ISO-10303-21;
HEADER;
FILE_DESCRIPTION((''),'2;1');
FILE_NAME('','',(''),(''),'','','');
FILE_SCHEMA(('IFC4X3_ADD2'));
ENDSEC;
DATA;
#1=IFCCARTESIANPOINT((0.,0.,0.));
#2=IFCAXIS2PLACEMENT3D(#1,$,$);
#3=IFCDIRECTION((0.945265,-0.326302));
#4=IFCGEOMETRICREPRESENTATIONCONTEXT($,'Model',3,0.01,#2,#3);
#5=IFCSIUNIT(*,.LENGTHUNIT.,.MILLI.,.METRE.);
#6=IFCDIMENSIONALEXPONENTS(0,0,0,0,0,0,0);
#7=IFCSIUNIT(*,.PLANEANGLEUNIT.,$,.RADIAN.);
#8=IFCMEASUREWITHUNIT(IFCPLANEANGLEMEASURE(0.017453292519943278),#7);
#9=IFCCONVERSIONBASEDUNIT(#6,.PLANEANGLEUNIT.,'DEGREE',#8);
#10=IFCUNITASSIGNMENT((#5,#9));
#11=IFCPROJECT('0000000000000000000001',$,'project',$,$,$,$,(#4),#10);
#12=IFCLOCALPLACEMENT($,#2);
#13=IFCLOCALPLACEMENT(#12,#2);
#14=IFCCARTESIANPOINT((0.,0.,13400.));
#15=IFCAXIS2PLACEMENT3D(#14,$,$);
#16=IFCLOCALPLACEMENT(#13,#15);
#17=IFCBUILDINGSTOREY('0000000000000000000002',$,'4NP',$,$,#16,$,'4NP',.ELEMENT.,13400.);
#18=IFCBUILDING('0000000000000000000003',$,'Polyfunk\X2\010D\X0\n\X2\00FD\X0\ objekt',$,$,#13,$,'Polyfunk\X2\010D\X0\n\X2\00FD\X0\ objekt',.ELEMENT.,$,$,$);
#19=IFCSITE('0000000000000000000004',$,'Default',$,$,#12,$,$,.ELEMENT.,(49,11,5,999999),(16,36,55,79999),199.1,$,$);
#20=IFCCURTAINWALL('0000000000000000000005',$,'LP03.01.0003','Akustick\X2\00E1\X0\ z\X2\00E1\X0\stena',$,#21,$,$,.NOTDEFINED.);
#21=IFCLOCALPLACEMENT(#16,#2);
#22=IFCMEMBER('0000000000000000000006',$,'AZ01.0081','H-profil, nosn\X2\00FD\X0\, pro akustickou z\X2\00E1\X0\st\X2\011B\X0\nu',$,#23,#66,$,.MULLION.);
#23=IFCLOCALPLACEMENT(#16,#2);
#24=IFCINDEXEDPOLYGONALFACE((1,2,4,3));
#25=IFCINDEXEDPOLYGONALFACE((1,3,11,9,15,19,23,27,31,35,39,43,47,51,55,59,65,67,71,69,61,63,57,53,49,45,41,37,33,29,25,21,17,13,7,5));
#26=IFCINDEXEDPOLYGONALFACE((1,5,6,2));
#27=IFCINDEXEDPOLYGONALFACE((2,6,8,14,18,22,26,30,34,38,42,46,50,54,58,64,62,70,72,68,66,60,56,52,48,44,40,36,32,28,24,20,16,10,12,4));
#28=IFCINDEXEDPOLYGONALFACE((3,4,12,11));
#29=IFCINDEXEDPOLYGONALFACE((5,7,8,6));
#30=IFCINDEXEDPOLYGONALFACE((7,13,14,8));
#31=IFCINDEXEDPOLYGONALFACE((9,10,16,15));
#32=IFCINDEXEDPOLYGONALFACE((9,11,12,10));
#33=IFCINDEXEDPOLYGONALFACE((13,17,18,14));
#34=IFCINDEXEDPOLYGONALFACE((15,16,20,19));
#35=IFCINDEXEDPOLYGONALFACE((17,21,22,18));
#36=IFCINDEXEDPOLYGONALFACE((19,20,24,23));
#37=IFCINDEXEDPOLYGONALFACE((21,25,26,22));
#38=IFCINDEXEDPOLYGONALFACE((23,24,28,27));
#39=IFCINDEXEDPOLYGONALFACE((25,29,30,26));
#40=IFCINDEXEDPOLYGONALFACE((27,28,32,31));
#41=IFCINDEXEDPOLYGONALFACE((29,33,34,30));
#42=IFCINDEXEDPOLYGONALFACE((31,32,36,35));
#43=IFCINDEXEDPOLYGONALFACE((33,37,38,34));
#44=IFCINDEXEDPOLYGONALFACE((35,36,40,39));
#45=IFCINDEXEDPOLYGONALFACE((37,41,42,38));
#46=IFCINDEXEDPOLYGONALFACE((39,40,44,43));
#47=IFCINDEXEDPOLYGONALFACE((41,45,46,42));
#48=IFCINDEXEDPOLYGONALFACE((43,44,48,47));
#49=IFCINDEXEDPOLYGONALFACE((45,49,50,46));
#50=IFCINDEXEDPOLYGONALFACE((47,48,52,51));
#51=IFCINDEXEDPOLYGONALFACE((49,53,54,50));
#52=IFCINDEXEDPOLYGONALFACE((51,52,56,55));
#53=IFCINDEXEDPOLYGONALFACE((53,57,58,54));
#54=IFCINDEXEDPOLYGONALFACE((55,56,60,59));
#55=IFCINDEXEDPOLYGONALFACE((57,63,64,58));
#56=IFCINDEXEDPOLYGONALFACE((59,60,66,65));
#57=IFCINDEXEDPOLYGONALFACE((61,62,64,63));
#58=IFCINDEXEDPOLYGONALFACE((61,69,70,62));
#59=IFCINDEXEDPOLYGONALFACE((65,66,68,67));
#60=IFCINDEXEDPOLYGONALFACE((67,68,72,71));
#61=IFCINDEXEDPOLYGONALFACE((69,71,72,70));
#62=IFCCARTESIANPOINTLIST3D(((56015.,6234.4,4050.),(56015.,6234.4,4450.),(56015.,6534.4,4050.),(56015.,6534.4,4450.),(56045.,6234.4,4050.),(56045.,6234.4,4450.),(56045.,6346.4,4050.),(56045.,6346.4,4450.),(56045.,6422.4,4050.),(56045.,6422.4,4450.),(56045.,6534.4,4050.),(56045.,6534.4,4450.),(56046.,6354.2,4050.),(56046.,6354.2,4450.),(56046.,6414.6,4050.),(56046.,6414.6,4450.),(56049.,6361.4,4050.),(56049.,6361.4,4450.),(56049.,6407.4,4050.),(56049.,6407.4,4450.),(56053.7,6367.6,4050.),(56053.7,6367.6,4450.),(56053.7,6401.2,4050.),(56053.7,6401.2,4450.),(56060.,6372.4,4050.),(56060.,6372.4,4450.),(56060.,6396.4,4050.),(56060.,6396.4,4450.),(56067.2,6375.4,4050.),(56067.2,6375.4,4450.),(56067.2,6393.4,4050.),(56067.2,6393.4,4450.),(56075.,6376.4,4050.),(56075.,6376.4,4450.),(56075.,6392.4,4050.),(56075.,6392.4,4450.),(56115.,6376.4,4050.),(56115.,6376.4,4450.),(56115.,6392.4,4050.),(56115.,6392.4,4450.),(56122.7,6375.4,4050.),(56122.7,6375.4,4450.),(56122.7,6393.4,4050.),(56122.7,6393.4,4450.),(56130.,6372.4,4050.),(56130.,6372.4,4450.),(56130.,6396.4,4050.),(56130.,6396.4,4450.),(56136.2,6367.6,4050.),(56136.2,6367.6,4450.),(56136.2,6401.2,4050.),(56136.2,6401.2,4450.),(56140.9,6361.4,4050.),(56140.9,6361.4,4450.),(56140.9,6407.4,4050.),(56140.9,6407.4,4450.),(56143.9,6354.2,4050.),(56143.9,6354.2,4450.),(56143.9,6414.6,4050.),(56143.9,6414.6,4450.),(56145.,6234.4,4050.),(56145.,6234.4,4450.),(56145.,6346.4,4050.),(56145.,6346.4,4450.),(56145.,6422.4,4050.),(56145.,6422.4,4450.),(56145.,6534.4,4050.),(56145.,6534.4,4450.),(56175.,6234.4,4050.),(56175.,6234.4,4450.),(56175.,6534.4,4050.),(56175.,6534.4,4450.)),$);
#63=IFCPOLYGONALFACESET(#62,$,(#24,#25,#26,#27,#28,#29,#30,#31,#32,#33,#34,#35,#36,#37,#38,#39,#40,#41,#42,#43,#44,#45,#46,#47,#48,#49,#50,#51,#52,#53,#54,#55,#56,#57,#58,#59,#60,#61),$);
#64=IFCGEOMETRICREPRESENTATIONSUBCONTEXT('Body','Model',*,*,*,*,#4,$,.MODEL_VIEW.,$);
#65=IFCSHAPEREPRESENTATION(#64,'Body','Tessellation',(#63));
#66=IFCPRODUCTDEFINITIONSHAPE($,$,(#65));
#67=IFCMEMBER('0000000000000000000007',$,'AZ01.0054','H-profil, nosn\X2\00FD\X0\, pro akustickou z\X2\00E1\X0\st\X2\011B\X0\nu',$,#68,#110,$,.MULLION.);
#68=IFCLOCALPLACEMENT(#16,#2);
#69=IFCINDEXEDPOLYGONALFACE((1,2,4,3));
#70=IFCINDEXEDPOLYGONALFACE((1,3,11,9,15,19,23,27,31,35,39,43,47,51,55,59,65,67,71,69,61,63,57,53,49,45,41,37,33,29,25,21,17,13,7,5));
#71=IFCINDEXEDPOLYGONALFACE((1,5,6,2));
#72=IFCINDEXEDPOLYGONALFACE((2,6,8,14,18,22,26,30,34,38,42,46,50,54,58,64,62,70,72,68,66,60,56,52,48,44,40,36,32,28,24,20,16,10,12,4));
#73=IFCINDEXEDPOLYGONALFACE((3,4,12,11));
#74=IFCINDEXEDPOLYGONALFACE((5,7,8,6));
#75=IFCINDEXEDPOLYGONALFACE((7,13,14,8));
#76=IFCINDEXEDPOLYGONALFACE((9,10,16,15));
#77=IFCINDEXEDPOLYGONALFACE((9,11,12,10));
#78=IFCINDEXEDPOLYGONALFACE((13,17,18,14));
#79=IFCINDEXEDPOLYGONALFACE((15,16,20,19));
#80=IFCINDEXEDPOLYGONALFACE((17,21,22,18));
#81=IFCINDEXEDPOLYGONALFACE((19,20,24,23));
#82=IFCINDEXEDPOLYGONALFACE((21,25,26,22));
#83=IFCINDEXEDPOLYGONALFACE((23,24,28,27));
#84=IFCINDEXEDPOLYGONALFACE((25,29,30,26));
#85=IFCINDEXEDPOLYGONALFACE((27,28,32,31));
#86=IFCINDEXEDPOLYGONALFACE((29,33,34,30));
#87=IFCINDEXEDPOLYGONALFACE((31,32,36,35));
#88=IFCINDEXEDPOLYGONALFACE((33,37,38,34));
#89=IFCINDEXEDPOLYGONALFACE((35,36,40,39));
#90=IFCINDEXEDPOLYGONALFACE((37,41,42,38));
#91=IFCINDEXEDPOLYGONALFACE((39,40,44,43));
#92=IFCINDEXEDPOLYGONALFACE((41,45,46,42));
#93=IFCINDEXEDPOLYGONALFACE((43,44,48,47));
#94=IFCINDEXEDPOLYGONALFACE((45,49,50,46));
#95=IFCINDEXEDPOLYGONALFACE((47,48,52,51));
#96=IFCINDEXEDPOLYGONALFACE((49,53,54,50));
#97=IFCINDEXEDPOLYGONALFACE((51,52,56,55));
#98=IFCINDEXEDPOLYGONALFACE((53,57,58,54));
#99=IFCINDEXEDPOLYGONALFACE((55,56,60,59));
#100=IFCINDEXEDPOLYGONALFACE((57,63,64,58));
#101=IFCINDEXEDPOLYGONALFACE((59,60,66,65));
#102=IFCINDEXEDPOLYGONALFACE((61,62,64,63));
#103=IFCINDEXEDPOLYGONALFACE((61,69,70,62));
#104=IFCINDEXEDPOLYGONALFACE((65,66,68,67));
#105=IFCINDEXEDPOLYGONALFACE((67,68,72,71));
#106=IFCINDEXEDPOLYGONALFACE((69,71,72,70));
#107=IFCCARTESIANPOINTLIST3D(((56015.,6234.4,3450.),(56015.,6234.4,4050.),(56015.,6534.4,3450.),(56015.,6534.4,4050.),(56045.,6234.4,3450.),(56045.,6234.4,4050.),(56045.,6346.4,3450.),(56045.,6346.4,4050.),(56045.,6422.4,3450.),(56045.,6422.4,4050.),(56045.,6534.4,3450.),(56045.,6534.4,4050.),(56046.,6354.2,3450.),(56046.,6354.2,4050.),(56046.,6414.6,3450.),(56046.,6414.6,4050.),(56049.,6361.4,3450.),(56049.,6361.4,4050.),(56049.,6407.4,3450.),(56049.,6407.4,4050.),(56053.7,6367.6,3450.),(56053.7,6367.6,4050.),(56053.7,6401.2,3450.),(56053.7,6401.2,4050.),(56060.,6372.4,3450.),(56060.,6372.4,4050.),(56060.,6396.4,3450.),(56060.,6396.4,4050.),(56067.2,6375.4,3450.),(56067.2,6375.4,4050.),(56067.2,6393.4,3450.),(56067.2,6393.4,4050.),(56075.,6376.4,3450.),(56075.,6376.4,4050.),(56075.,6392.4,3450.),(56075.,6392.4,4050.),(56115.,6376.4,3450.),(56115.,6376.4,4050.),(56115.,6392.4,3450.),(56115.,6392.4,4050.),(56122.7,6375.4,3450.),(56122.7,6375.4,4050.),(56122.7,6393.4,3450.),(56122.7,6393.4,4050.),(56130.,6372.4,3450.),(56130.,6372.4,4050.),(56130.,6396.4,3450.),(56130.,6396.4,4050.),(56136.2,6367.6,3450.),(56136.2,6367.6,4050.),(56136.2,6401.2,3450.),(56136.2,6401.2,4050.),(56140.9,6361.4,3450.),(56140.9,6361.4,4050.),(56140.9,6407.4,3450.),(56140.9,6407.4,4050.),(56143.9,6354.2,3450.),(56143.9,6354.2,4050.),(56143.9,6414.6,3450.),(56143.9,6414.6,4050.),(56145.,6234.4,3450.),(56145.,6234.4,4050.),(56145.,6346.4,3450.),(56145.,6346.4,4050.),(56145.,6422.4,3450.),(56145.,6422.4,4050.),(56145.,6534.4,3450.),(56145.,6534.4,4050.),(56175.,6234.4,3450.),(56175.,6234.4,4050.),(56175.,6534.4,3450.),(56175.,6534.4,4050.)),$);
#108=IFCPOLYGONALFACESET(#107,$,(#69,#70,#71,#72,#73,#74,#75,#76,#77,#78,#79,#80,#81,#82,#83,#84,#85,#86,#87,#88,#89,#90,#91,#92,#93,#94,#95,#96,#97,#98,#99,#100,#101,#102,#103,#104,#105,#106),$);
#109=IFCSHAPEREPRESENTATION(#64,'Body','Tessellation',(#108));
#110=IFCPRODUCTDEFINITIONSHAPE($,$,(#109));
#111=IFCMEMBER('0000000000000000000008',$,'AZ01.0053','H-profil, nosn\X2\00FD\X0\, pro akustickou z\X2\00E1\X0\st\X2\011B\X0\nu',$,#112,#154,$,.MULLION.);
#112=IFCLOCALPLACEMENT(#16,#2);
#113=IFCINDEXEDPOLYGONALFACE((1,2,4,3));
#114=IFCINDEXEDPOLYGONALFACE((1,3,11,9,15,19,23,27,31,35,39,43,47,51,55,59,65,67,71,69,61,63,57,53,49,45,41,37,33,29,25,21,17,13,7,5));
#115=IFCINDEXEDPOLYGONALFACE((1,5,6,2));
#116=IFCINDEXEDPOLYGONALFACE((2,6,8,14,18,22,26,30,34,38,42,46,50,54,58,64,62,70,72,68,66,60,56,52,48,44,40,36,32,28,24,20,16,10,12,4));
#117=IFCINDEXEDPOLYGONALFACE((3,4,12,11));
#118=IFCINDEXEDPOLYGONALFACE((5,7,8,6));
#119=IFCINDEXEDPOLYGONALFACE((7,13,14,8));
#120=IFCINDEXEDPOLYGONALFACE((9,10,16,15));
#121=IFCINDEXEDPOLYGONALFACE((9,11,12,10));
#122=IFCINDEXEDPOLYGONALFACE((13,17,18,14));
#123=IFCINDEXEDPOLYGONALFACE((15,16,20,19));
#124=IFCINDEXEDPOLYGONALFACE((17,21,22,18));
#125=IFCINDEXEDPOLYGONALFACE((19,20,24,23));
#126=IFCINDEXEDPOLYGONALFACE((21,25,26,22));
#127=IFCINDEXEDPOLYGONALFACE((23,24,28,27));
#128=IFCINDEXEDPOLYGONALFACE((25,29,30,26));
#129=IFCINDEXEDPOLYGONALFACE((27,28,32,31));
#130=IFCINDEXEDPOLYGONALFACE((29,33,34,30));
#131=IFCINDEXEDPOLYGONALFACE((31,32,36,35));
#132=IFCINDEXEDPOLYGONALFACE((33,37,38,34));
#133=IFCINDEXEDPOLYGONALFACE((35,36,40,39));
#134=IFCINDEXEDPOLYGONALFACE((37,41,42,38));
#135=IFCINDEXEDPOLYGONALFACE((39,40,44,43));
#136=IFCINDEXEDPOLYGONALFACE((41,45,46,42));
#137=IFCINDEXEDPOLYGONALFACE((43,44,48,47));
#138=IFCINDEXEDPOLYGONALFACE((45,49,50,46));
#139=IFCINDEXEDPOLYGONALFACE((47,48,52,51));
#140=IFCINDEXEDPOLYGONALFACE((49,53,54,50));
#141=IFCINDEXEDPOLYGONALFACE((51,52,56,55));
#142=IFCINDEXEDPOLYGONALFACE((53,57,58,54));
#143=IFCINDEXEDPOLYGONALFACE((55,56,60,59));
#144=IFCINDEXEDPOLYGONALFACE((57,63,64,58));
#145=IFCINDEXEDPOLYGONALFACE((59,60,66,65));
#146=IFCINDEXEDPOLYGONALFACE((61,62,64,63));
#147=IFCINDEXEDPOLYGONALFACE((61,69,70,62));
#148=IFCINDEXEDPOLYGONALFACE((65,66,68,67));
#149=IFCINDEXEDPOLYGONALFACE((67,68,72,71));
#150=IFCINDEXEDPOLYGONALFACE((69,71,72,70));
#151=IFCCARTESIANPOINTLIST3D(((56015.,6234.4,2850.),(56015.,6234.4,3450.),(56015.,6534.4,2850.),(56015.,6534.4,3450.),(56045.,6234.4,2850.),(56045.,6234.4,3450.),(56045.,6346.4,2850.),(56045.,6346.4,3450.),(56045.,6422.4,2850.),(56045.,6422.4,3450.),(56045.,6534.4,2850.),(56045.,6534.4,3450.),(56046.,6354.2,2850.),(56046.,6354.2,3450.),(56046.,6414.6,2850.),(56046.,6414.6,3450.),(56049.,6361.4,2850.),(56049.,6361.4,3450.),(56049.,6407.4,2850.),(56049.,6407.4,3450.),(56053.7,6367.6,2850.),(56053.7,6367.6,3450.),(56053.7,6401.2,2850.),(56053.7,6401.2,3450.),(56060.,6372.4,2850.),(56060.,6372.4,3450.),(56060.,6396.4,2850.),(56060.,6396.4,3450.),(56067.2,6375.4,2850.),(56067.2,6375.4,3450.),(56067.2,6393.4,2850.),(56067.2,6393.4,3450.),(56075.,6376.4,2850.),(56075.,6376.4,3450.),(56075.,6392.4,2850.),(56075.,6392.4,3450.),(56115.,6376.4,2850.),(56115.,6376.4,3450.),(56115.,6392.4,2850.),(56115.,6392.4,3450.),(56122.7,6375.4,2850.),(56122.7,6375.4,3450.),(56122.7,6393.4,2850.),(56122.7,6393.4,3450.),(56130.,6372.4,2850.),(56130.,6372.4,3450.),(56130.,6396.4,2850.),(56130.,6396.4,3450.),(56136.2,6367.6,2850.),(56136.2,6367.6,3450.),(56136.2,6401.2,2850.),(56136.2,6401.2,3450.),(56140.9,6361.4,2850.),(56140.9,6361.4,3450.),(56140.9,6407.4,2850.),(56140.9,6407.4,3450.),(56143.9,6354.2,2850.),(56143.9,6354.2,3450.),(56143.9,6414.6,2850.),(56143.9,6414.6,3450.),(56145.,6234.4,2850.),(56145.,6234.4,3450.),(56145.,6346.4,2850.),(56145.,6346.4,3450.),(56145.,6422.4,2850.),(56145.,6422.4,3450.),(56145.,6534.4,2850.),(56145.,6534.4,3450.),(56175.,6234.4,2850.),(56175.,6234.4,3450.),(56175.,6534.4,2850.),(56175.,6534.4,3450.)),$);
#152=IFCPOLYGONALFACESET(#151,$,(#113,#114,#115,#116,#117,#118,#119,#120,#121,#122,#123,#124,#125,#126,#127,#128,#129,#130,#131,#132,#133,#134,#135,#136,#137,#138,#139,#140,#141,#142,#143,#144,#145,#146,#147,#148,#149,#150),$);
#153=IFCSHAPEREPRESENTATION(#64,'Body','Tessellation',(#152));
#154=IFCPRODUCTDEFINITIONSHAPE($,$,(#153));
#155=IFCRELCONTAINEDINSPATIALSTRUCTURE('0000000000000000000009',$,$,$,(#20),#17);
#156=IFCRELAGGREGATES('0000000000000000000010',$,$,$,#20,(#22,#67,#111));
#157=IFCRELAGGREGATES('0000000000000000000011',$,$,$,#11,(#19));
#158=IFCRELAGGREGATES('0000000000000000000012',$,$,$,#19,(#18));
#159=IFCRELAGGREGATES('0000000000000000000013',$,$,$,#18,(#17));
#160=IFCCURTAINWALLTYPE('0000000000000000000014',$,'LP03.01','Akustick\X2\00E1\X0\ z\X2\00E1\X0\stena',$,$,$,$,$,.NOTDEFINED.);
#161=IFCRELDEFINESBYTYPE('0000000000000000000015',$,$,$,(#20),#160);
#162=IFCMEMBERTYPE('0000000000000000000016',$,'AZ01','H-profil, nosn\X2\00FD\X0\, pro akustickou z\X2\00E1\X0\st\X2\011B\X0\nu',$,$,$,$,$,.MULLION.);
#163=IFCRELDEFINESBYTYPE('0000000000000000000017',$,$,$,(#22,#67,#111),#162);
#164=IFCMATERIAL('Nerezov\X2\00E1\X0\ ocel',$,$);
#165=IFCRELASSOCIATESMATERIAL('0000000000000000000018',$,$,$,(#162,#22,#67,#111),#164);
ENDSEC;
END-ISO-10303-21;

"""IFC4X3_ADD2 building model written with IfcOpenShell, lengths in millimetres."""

from ifc_helpers import new_model, entity, si_unit, converted_unit, direction, frame, frame_2d, origin, place, context, subcontext, project, spatial, polyline, circle_curve, parameter, trimmed, segment, composite_curve, outline, extrude, source, transform, mapped, material, material_profile, profile_set, profile_usage, type_object, element, aggregate, save


model = new_model("IFC4X3_ADD2")

# Units and contexts
model_context = context("Model", 3, precision=0.01, world=origin(), true_north=direction((0.945265, -0.326302)))
body_context = subcontext(model_context, "Body", "Model", "MODEL_VIEW")
ifc_project = project(units=[si_unit("LENGTHUNIT", "METRE", prefix="MILLI"), converted_unit("PLANEANGLEUNIT", "DEGREE", entity("IfcPlaneAngleMeasure", 0.017453292519943278), si_unit("PLANEANGLEUNIT", "RADIAN"), dimensions=[0, 0, 0, 0, 0, 0, 0])], contexts=[model_context])

# Site, building, storey
site_placement = place(None, origin())
site = spatial("IfcSite", under=ifc_project, at=site_placement, Name="Default", CompositionType="ELEMENT", RefLatitude=(49, 11, 5, 999999), RefLongitude=(16, 36, 55, 79999), RefElevation=199.1)
building_placement = place(site_placement, origin())
building = spatial("IfcBuilding", under=site, at=building_placement, Name="Polyfunkčný objekt", LongName="Polyfunkčný objekt", CompositionType="ELEMENT")
storey_placement = place(building_placement, frame((0.0, 0.0, 13400.0)))
storey = spatial("IfcBuildingStorey", under=building, at=storey_placement, Name="4NP", LongName="4NP", CompositionType="ELEMENT", Elevation=13400.0)

# Shared definitions
curtain_wall_type = type_object("IfcCurtainWallType", Name="LP03.01", Description="Akustická zástena", PredefinedType="NOTDEFINED")
ifc_material_1 = material(Name="Nerezová ocel")
ifc_material_profile = material_profile(ifc_material_1, outline(composite_curve([segment(polyline([(50.0, -150.0), (80.0, -150.0)]), True, "CONTINUOUS"), segment(polyline([(80.0, -150.0), (80.0, 150.0)]), True, "CONTINUOUS"), segment(polyline([(80.0, 150.0), (50.0, 150.0)]), True, "CONTINUOUS"), segment(polyline([(50.0, 150.0), (50.0, 38.0)]), True, "CONTINUOUS"), segment(trimmed(circle_curve(frame_2d((20.0, 38.0), x_axis=(0.0, 1.0)), 30.0), [parameter(180.0)], [parameter(270.0)], True, "PARAMETER"), False, "CONTINUOUS"), segment(polyline([(20.0, 8.0), (-20.0, 8.0)]), True, "CONTINUOUS"), segment(trimmed(circle_curve(frame_2d((-20.0, 38.0), x_axis=(0.0, 1.0)), 30.0), [parameter(90.0)], [parameter(180.0)], True, "PARAMETER"), False, "CONTINUOUS"), segment(polyline([(-50.0, 38.0), (-50.0, 150.0)]), True, "CONTINUOUS"), segment(polyline([(-50.0, 150.0), (-80.0, 150.0)]), True, "CONTINUOUS"), segment(polyline([(-80.0, 150.0), (-80.0, -150.0)]), True, "CONTINUOUS"), segment(polyline([(-80.0, -150.0), (-50.0, -150.0)]), True, "CONTINUOUS"), segment(polyline([(-50.0, -150.0), (-50.0, -38.0)]), True, "CONTINUOUS"), segment(trimmed(circle_curve(frame_2d((-20.0, -38.0), x_axis=(0.0, 1.0)), 30.0), [parameter(0.0)], [parameter(90.0)], True, "PARAMETER"), False, "CONTINUOUS"), segment(polyline([(-20.0, -8.0), (20.0, -8.0)]), True, "CONTINUOUS"), segment(trimmed(circle_curve(frame_2d((20.0, -38.0), x_axis=(0.0, 1.0)), 30.0), [parameter(270.0)], [parameter(0.0)], True, "PARAMETER"), False, "CONTINUOUS"), segment(polyline([(50.0, -38.0), (50.0, -150.0)]), True, "CONTINUOUS")], self_intersect=False)), Name="Profil zástena")
ifc_profile_set = profile_set([ifc_material_profile], Name="Profil zástena")
ifc_profile_usage = profile_usage(ifc_profile_set)
member_type = type_object("IfcMemberType", Name="AZ01", Description="H-profil, nosný, pro akustickou zástěnu", PredefinedType="MULLION", material=ifc_profile_set)

# Curtain wall, members
curtain_wall_1_placement = place(storey_placement, frame((0.0, 0.0, -13400.0)))
curtain_wall_1 = element("IfcCurtainWall", 1, at=curtain_wall_1_placement, inside=storey, type_object=curtain_wall_type, Name="LP03.01.0003", Description="Akustická zástena", PredefinedType="NOTDEFINED")
shared_shape_1 = source(origin(), body_context, "Body", "SweptSolid", [
    extrude(outline(composite_curve([segment(polyline([(-150.0, -50.0), (-150.0, -80.0)]), True, "CONTINUOUS"), segment(polyline([(-150.0, -80.0), (150.0, -80.0)]), True, "CONTINUOUS"), segment(polyline([(150.0, -80.0), (150.0, -50.0)]), True, "CONTINUOUS"), segment(polyline([(150.0, -50.0), (38.0, -50.0)]), True, "CONTINUOUS"), segment(trimmed(circle_curve(frame_2d((38.0, -20.0), x_axis=(1.0, 0.0)), 30.0), [parameter(180.0)], [parameter(270.0)], True, "PARAMETER"), False, "CONTINUOUS"), segment(polyline([(8.0, -20.0), (8.0, 20.0)]), True, "CONTINUOUS"), segment(trimmed(circle_curve(frame_2d((38.0, 20.0), x_axis=(1.0, 0.0)), 30.0), [parameter(90.0)], [parameter(180.0)], True, "PARAMETER"), False, "CONTINUOUS"), segment(polyline([(38.0, 50.0), (150.0, 50.0)]), True, "CONTINUOUS"), segment(polyline([(150.0, 50.0), (150.0, 80.0)]), True, "CONTINUOUS"), segment(polyline([(150.0, 80.0), (-150.0, 80.0)]), True, "CONTINUOUS"), segment(polyline([(-150.0, 80.0), (-150.0, 50.0)]), True, "CONTINUOUS"), segment(polyline([(-150.0, 50.0), (-38.0, 50.0)]), True, "CONTINUOUS"), segment(trimmed(circle_curve(frame_2d((-38.0, 20.0), x_axis=(1.0, 0.0)), 30.0), [parameter(0.0)], [parameter(90.0)], True, "PARAMETER"), False, "CONTINUOUS"), segment(polyline([(-8.0, 20.0), (-8.0, -20.0)]), True, "CONTINUOUS"), segment(trimmed(circle_curve(frame_2d((-38.0, -20.0), x_axis=(1.0, 0.0)), 30.0), [parameter(270.0)], [parameter(0.0)], True, "PARAMETER"), False, "CONTINUOUS"), segment(polyline([(-38.0, -50.0), (-150.0, -50.0)]), True, "CONTINUOUS")], self_intersect=False)), frame((-150.0, 0.0, -400.0), z_axis=(0.0, 0.0, -1.0), x_axis=(1.0, 0.0, 0.0)), (0.0, 0.0, -1.0), 400.0),
])
member_1_placement = place(curtain_wall_1_placement, frame((56095.0, 6534.4, 17450.0), z_axis=(0.0, 0.0, -1.0), x_axis=(0.0, 1.0, 0.0)))
member_1 = element("IfcMember", 2, at=member_1_placement, type_object=member_type, material=ifc_profile_usage, Name="AZ01.0081", Description="H-profil, nosný, pro akustickou zástěnu", PredefinedType="MULLION", context=body_context, shape_type="MappedRepresentation", body=[
    mapped(shared_shape_1, transform((0.0, 0.0, 0.0), scale=1.0)),
])
shared_shape_2 = source(origin(), body_context, "Body", "SweptSolid", [
    extrude(outline(composite_curve([segment(polyline([(-150.0, -50.0), (-150.0, -80.0)]), True, "CONTINUOUS"), segment(polyline([(-150.0, -80.0), (150.0, -80.0)]), True, "CONTINUOUS"), segment(polyline([(150.0, -80.0), (150.0, -50.0)]), True, "CONTINUOUS"), segment(polyline([(150.0, -50.0), (38.0, -50.0)]), True, "CONTINUOUS"), segment(trimmed(circle_curve(frame_2d((38.0, -20.0), x_axis=(1.0, 0.0)), 30.0), [parameter(180.0)], [parameter(270.0)], True, "PARAMETER"), False, "CONTINUOUS"), segment(polyline([(8.0, -20.0), (8.0, 20.0)]), True, "CONTINUOUS"), segment(trimmed(circle_curve(frame_2d((38.0, 20.0), x_axis=(1.0, 0.0)), 30.0), [parameter(90.0)], [parameter(180.0)], True, "PARAMETER"), False, "CONTINUOUS"), segment(polyline([(38.0, 50.0), (150.0, 50.0)]), True, "CONTINUOUS"), segment(polyline([(150.0, 50.0), (150.0, 80.0)]), True, "CONTINUOUS"), segment(polyline([(150.0, 80.0), (-150.0, 80.0)]), True, "CONTINUOUS"), segment(polyline([(-150.0, 80.0), (-150.0, 50.0)]), True, "CONTINUOUS"), segment(polyline([(-150.0, 50.0), (-38.0, 50.0)]), True, "CONTINUOUS"), segment(trimmed(circle_curve(frame_2d((-38.0, 20.0), x_axis=(1.0, 0.0)), 30.0), [parameter(0.0)], [parameter(90.0)], True, "PARAMETER"), False, "CONTINUOUS"), segment(polyline([(-8.0, 20.0), (-8.0, -20.0)]), True, "CONTINUOUS"), segment(trimmed(circle_curve(frame_2d((-38.0, -20.0), x_axis=(1.0, 0.0)), 30.0), [parameter(270.0)], [parameter(0.0)], True, "PARAMETER"), False, "CONTINUOUS"), segment(polyline([(-38.0, -50.0), (-150.0, -50.0)]), True, "CONTINUOUS")], self_intersect=False)), frame((-150.0, 0.0, -600.0), z_axis=(0.0, 0.0, -1.0), x_axis=(1.0, 0.0, 0.0)), (0.0, 0.0, -1.0), 600.0),
])
member_2_placement = place(curtain_wall_1_placement, frame((56095.0, 6534.4, 16850.0), z_axis=(0.0, 0.0, -1.0), x_axis=(0.0, 1.0, 0.0)))
member_2 = element("IfcMember", 3, at=member_2_placement, type_object=member_type, material=ifc_profile_usage, Name="AZ01.0054", Description="H-profil, nosný, pro akustickou zástěnu", PredefinedType="MULLION", context=body_context, shape_type="MappedRepresentation", body=[
    mapped(shared_shape_2, transform((0.0, 0.0, 0.0), scale=1.0)),
])
member_3_placement = place(curtain_wall_1_placement, frame((56095.0, 6534.4, 16250.0), z_axis=(0.0, 0.0, -1.0), x_axis=(0.0, 1.0, 0.0)))
member_3 = element("IfcMember", 4, at=member_3_placement, type_object=member_type, material=ifc_profile_usage, Name="AZ01.0053", Description="H-profil, nosný, pro akustickou zástěnu", PredefinedType="MULLION", context=body_context, shape_type="MappedRepresentation", body=[
    mapped(shared_shape_2, transform((0.0, 0.0, 0.0), scale=1.0)),
])
aggregate(curtain_wall_1, [member_1, member_2, member_3])

save(model, "model.ifc")
